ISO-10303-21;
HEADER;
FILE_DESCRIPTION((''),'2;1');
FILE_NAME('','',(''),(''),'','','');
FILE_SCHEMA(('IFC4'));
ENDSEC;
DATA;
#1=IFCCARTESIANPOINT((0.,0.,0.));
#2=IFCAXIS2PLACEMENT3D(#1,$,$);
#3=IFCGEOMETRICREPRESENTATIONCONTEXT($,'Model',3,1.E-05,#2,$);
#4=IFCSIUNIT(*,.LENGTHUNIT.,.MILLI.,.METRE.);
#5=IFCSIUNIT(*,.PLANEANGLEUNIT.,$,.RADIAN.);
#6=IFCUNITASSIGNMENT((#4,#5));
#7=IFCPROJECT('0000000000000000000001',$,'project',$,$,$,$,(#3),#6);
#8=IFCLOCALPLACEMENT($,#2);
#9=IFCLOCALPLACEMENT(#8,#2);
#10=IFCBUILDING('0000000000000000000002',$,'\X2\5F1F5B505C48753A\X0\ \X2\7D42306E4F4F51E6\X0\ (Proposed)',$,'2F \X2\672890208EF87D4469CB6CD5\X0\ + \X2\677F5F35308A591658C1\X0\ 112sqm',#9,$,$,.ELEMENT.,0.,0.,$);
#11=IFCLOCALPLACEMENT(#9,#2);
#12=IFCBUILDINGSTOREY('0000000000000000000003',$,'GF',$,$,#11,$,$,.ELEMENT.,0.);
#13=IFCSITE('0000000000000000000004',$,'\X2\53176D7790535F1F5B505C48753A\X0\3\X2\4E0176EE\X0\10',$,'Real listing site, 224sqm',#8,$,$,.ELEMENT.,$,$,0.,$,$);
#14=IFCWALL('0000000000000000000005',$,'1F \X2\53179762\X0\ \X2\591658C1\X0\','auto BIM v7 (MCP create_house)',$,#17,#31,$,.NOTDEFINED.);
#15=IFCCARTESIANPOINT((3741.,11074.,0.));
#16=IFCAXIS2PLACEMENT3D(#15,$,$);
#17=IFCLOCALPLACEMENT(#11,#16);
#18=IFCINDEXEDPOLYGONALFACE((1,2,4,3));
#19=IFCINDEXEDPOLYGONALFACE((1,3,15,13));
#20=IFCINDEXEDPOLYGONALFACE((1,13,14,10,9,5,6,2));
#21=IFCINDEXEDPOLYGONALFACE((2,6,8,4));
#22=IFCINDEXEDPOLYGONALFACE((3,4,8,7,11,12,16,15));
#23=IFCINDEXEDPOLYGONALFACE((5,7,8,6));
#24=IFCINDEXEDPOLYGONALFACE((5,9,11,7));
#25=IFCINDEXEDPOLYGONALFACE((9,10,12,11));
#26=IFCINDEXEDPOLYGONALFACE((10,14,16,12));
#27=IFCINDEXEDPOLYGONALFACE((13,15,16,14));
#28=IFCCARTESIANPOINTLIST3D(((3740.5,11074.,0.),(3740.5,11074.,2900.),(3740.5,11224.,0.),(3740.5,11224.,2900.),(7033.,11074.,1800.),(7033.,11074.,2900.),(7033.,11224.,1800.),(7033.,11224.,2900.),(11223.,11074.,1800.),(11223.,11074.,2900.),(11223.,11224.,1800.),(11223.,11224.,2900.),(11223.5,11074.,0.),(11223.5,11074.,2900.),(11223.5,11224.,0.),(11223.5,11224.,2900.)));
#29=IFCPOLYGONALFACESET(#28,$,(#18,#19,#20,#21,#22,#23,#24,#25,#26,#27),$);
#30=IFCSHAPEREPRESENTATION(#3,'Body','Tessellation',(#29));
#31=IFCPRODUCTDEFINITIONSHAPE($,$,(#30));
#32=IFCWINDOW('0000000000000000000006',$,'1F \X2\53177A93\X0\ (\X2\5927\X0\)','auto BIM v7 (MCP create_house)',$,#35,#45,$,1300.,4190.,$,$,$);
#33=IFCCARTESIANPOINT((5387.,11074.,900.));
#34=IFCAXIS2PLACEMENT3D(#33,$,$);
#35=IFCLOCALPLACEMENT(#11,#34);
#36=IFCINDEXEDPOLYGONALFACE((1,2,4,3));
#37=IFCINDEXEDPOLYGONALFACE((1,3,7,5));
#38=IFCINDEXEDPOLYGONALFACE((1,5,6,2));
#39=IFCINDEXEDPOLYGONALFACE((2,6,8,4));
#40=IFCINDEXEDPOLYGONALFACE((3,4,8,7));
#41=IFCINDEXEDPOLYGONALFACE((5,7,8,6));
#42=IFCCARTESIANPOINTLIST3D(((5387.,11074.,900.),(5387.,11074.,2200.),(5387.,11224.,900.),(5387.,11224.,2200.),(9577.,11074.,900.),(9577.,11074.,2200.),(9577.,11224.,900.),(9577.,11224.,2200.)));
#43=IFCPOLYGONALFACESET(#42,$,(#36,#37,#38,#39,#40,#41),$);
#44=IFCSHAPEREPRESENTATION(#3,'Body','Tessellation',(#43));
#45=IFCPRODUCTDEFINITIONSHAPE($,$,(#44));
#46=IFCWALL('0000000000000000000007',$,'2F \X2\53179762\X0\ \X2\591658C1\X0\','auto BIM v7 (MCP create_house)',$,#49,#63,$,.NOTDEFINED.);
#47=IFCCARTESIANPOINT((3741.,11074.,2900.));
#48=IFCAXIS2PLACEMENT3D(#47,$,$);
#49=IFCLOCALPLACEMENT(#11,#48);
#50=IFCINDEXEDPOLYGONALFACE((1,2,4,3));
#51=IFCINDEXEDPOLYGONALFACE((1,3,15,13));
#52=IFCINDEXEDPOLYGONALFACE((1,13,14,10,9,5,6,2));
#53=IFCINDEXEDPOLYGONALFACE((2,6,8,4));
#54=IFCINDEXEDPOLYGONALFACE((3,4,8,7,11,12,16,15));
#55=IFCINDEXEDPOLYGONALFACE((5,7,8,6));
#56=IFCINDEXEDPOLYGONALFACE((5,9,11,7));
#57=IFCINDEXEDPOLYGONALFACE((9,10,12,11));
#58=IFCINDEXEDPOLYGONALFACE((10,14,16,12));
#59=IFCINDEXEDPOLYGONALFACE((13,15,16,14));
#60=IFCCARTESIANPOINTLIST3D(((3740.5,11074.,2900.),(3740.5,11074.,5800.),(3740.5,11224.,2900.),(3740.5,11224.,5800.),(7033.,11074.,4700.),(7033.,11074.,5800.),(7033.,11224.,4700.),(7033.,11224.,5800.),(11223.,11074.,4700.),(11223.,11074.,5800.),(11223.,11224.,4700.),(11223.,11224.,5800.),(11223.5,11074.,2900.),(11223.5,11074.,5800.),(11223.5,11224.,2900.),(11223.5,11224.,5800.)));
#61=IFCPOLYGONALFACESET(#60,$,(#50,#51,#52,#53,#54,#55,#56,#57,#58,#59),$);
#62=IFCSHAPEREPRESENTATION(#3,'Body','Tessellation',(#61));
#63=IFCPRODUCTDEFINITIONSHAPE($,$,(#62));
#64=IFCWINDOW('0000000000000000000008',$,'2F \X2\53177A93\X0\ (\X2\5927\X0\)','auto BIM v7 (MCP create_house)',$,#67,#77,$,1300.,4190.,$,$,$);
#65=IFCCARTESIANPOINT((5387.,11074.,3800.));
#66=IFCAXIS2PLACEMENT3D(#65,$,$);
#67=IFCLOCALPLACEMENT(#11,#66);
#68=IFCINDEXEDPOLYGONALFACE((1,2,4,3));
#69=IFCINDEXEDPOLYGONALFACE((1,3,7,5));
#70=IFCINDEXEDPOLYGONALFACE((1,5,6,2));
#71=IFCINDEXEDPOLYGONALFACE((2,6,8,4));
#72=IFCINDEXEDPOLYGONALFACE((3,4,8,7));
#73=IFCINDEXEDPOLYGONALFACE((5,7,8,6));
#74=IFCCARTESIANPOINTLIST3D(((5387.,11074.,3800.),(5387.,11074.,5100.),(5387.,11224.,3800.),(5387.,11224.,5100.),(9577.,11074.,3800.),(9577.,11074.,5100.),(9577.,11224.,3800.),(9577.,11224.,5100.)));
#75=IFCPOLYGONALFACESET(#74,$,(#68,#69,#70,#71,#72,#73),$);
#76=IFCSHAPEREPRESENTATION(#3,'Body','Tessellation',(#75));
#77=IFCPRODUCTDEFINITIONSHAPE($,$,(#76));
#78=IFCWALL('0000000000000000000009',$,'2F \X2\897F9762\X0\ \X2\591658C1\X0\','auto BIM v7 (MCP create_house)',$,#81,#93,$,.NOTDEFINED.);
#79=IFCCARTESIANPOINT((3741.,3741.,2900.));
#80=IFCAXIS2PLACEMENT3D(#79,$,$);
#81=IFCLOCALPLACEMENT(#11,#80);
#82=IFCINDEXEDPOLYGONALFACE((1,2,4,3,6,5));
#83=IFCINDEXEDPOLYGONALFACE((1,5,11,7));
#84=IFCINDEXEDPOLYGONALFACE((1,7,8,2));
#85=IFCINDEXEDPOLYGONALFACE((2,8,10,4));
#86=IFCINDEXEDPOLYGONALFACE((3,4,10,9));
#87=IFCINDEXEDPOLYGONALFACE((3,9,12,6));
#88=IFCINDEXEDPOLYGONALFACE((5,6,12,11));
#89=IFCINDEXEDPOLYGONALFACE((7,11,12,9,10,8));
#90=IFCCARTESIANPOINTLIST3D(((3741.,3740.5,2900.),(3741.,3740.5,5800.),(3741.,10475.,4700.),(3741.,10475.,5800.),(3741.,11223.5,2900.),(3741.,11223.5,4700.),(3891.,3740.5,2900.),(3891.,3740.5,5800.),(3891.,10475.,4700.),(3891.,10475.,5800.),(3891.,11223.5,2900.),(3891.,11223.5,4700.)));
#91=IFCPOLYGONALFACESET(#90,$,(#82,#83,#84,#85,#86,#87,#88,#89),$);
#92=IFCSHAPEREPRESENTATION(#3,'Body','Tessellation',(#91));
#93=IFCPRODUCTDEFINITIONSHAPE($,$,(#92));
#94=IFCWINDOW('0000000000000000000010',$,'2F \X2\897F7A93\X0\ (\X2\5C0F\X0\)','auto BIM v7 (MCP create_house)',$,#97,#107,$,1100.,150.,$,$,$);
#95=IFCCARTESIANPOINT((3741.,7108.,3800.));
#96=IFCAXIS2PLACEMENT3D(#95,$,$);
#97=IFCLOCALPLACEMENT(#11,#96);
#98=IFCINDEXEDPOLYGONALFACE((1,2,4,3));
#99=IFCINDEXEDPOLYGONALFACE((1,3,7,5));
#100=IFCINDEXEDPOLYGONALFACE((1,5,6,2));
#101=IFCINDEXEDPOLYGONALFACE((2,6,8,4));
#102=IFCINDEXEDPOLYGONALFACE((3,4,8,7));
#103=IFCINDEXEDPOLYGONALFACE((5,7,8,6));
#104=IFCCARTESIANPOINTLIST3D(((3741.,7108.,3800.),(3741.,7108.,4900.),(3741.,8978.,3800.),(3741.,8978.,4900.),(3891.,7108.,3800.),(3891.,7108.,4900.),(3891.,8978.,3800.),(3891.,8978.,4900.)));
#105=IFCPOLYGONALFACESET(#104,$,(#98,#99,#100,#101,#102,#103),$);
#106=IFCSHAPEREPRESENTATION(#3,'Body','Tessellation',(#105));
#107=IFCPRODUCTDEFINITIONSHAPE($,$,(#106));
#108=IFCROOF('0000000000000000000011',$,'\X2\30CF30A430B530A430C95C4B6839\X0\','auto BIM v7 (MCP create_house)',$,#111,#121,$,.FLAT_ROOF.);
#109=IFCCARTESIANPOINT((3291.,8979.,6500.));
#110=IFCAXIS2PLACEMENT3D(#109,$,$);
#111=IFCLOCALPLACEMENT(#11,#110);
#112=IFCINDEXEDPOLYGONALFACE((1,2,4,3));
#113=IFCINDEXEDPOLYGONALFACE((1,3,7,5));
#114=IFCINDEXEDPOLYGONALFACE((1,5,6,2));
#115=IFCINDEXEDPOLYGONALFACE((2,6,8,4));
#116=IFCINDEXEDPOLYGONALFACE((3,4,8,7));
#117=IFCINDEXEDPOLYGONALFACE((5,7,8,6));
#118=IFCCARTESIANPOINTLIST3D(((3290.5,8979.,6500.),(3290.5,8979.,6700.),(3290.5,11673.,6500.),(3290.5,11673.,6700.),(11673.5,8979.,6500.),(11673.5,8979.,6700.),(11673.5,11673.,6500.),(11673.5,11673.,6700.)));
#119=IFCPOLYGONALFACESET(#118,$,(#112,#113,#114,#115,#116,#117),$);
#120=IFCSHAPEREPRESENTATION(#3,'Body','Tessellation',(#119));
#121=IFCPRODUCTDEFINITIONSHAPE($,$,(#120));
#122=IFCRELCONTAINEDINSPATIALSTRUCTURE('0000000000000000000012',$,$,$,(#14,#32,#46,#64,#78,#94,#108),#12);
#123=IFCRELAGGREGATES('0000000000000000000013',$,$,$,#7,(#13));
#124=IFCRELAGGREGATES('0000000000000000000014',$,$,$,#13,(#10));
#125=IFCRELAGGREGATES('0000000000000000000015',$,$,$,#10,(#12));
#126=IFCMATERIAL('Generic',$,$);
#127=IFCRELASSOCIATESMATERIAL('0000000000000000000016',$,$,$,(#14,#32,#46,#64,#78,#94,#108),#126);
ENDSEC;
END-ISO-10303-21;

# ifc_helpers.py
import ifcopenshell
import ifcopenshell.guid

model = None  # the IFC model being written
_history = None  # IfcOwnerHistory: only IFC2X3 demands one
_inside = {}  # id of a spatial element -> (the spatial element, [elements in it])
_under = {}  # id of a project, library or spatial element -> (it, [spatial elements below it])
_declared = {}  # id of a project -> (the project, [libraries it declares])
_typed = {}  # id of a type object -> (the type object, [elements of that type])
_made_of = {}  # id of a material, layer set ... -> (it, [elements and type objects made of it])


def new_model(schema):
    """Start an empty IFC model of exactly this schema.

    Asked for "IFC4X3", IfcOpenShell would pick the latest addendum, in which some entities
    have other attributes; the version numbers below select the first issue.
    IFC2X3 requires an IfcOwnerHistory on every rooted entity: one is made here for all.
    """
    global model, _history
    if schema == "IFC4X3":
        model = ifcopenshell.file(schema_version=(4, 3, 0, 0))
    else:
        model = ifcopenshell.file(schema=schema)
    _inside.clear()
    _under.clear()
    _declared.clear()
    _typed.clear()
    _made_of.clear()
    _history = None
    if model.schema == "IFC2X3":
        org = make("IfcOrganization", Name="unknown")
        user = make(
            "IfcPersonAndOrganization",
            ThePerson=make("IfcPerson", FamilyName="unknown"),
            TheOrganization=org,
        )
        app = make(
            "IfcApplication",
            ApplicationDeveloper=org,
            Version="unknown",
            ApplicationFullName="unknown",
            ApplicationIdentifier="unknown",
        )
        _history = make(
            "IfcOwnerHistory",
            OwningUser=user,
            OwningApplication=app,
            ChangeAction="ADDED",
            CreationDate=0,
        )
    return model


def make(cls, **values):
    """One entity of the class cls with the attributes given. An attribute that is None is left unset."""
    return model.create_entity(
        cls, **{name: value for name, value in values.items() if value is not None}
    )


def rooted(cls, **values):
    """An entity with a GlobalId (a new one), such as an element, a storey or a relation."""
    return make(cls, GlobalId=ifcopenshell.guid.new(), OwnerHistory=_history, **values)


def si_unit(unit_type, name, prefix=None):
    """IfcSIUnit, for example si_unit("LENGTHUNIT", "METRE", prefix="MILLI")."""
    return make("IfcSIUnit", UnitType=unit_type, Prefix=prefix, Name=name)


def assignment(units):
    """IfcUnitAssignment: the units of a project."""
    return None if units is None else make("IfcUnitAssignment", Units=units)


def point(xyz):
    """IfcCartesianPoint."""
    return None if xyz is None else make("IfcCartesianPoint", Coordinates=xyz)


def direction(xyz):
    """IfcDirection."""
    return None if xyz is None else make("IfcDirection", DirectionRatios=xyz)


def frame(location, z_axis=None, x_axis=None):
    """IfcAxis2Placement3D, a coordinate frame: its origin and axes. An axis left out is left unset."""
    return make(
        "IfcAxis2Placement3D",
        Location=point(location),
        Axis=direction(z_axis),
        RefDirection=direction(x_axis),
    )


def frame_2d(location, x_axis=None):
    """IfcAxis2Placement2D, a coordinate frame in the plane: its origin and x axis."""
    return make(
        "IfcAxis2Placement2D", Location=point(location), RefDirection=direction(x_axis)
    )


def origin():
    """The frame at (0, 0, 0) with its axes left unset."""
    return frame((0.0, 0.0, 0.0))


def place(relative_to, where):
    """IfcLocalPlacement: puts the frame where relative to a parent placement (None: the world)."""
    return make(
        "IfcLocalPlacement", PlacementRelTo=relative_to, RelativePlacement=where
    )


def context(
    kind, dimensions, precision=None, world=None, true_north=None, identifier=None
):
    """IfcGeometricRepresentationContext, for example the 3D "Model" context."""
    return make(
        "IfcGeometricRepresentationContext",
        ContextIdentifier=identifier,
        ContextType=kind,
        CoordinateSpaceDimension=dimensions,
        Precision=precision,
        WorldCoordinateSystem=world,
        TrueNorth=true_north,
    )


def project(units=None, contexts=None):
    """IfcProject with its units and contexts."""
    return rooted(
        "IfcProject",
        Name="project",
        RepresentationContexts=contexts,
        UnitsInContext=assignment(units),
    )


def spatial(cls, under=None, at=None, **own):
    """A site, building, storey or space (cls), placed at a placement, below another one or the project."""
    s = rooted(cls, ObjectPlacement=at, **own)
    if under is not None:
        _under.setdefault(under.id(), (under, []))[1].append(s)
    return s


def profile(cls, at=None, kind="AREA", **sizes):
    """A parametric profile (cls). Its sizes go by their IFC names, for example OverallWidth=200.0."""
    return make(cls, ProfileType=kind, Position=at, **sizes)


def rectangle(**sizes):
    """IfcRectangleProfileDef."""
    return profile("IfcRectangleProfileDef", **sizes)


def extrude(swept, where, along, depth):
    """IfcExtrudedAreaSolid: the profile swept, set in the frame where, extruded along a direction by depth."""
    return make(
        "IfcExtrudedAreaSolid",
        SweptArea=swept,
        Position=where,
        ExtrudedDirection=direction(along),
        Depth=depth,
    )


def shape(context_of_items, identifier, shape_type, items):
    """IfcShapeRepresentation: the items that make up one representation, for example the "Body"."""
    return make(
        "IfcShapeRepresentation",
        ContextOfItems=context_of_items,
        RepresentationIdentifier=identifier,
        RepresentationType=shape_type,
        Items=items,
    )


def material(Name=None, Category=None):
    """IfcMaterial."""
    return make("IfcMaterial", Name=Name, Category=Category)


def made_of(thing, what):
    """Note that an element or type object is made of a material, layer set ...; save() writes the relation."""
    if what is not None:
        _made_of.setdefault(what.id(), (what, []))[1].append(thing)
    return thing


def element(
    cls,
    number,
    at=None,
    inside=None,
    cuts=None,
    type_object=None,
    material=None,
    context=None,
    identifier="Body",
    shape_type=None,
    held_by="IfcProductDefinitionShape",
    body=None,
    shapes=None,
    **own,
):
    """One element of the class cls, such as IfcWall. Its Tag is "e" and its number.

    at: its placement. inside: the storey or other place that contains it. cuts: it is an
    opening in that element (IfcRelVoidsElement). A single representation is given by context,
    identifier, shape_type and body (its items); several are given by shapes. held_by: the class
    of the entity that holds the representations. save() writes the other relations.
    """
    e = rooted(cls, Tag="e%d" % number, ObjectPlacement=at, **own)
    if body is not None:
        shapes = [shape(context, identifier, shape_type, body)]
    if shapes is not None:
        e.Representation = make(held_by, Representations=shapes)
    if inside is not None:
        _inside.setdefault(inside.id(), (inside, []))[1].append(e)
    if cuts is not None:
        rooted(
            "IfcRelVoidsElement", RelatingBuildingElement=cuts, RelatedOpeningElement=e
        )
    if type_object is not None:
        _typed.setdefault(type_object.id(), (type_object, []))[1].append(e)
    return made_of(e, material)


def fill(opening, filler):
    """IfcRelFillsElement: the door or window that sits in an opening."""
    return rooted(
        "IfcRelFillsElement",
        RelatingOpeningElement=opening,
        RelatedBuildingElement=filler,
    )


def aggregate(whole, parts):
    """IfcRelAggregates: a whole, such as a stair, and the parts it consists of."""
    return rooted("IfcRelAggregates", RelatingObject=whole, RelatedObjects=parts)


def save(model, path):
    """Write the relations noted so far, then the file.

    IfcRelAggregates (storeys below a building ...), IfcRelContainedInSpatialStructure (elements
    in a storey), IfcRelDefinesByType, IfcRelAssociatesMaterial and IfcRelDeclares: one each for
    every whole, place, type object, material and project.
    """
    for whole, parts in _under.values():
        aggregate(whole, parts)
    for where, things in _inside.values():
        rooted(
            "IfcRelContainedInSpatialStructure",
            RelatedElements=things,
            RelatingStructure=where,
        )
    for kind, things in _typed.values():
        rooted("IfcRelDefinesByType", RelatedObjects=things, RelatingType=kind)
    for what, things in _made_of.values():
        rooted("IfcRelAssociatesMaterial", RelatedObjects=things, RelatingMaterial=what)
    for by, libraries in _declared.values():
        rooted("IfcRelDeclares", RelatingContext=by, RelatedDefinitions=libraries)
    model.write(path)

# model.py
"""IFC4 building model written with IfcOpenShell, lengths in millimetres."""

from ifc_helpers import new_model, si_unit, frame, frame_2d, origin, place, context, project, spatial, rectangle, extrude, material, element, fill, save


model = new_model("IFC4")

# Units and contexts
model_context = context("Model", 3, precision=1e-05, world=origin())
ifc_project = project(units=[si_unit("LENGTHUNIT", "METRE", prefix="MILLI"), si_unit("PLANEANGLEUNIT", "RADIAN")], contexts=[model_context])

# Site, building, storey
site_placement = place(None, origin())
site = spatial("IfcSite", under=ifc_project, at=site_placement, Name="北海道弟子屈町3丁目10", ObjectType="Real listing site, 224sqm", CompositionType="ELEMENT", RefElevation=0.0)
building_placement = place(site_placement, origin())
building = spatial("IfcBuilding", under=site, at=building_placement, Name="弟子屈町 終の住処 (Proposed)", ObjectType="2F 木造軸組構法 + 板張り外壁 112sqm", CompositionType="ELEMENT", ElevationOfRefHeight=0.0, ElevationOfTerrain=0.0)
storey_placement = place(building_placement, origin())
storey = spatial("IfcBuildingStorey", under=building, at=storey_placement, Name="GF", CompositionType="ELEMENT", Elevation=0.0)

# Wall, opening, window
ifc_material = material(Name="Generic")
wall_1_placement = place(storey_placement, frame((3741.0, 11074.0, 0.0)))
wall_1 = element("IfcWall", 1, at=wall_1_placement, inside=storey, material=ifc_material, Name="1F 北面 外壁", Description="auto BIM v7 (MCP create_house)", PredefinedType="NOTDEFINED", context=model_context, shape_type="SweptSolid", body=[
    extrude(rectangle(XDim=7483.0, YDim=150.0, at=frame_2d((3741.0, 75.0))), frame((3741.0, 11074.0, 0.0)), (0.0, 0.0, 1.0), 2900.0),
])
opening_1_placement = place(storey_placement, frame((5387.0, 11074.0, 900.0)))
opening_1 = element("IfcOpeningElement", 2, at=opening_1_placement, cuts=wall_1, PredefinedType="NOTDEFINED", context=model_context, shape_type="SweptSolid", body=[
    extrude(rectangle(XDim=4190.0, YDim=150.0, at=frame_2d((2095.0, 75.0))), frame((5387.0, 11074.0, 900.0)), (0.0, 0.0, 1.0), 1300.0),
])
window_1_placement = place(storey_placement, frame((5387.0, 11074.0, 900.0)))
window_1 = element("IfcWindow", 3, at=window_1_placement, inside=storey, material=ifc_material, Name="1F 北窓 (大)", Description="auto BIM v7 (MCP create_house)", OverallHeight=1300.0, OverallWidth=4190.0, context=model_context, shape_type="SweptSolid", body=[
    extrude(rectangle(XDim=4190.0, YDim=150.0, at=frame_2d((2095.0, 75.0))), frame((5387.0, 11074.0, 900.0)), (0.0, 0.0, 1.0), 1300.0),
])
fill(opening_1, window_1)

# Walls, openings, windows
wall_2_placement = place(storey_placement, frame((3741.0, 11074.0, 2900.0)))
wall_2 = element("IfcWall", 4, at=wall_2_placement, inside=storey, material=ifc_material, Name="2F 北面 外壁", Description="auto BIM v7 (MCP create_house)", PredefinedType="NOTDEFINED", context=model_context, shape_type="SweptSolid", body=[
    extrude(rectangle(XDim=7483.0, YDim=150.0, at=frame_2d((3741.0, 75.0))), frame((3741.0, 11074.0, 2900.0)), (0.0, 0.0, 1.0), 2900.0),
])
opening_2_placement = place(storey_placement, frame((5387.0, 11074.0, 3800.0)))
opening_2 = element("IfcOpeningElement", 5, at=opening_2_placement, cuts=wall_2, PredefinedType="NOTDEFINED", context=model_context, shape_type="SweptSolid", body=[
    extrude(rectangle(XDim=4190.0, YDim=150.0, at=frame_2d((2095.0, 75.0))), frame((5387.0, 11074.0, 3800.0)), (0.0, 0.0, 1.0), 1300.0),
])
window_2_placement = place(storey_placement, frame((5387.0, 11074.0, 3800.0)))
window_2 = element("IfcWindow", 6, at=window_2_placement, inside=storey, material=ifc_material, Name="2F 北窓 (大)", Description="auto BIM v7 (MCP create_house)", OverallHeight=1300.0, OverallWidth=4190.0, context=model_context, shape_type="SweptSolid", body=[
    extrude(rectangle(XDim=4190.0, YDim=150.0, at=frame_2d((2095.0, 75.0))), frame((5387.0, 11074.0, 3800.0)), (0.0, 0.0, 1.0), 1300.0),
])
fill(opening_2, window_2)
wall_3_placement = place(storey_placement, frame((3741.0, 3741.0, 2900.0)))
wall_3 = element("IfcWall", 7, at=wall_3_placement, inside=storey, material=ifc_material, Name="2F 西面 外壁", Description="auto BIM v7 (MCP create_house)", PredefinedType="NOTDEFINED", context=model_context, shape_type="SweptSolid", body=[
    extrude(rectangle(XDim=150.0, YDim=7483.0, at=frame_2d((75.0, 3741.0))), frame((3741.0, 3741.0, 2900.0)), (0.0, 0.0, 1.0), 2900.0),
])
opening_3_placement = place(storey_placement, frame((3741.0, 7108.0, 3800.0)))
opening_3 = element("IfcOpeningElement", 8, at=opening_3_placement, cuts=wall_3, PredefinedType="NOTDEFINED", context=model_context, shape_type="SweptSolid", body=[
    extrude(rectangle(XDim=150.0, YDim=1870.0, at=frame_2d((75.0, 935.0))), frame((3741.0, 7108.0, 3800.0)), (0.0, 0.0, 1.0), 1100.0),
])
window_3_placement = place(storey_placement, frame((3741.0, 7108.0, 3800.0)))
window_3 = element("IfcWindow", 9, at=window_3_placement, inside=storey, material=ifc_material, Name="2F 西窓 (小)", Description="auto BIM v7 (MCP create_house)", OverallHeight=1100.0, OverallWidth=150.0, context=model_context, shape_type="SweptSolid", body=[
    extrude(rectangle(XDim=150.0, YDim=1870.0, at=frame_2d((75.0, 935.0))), frame((3741.0, 7108.0, 3800.0)), (0.0, 0.0, 1.0), 1100.0),
])
fill(opening_3, window_3)

# Roof
roof_placement = place(storey_placement, frame((3291.0, 8979.0, 6500.0)))
element("IfcRoof", 10, at=roof_placement, inside=storey, material=ifc_material, Name="ハイサイド屋根", Description="auto BIM v7 (MCP create_house)", PredefinedType="FLAT_ROOF", context=model_context, shape_type="SweptSolid", body=[
    extrude(rectangle(XDim=8383.0, YDim=2694.0, at=frame_2d((4191.0, 1347.0))), frame((3291.0, 8979.0, 6500.0)), (0.0, 0.0, 1.0), 200.0),
])

save(model, "model.ifc")
